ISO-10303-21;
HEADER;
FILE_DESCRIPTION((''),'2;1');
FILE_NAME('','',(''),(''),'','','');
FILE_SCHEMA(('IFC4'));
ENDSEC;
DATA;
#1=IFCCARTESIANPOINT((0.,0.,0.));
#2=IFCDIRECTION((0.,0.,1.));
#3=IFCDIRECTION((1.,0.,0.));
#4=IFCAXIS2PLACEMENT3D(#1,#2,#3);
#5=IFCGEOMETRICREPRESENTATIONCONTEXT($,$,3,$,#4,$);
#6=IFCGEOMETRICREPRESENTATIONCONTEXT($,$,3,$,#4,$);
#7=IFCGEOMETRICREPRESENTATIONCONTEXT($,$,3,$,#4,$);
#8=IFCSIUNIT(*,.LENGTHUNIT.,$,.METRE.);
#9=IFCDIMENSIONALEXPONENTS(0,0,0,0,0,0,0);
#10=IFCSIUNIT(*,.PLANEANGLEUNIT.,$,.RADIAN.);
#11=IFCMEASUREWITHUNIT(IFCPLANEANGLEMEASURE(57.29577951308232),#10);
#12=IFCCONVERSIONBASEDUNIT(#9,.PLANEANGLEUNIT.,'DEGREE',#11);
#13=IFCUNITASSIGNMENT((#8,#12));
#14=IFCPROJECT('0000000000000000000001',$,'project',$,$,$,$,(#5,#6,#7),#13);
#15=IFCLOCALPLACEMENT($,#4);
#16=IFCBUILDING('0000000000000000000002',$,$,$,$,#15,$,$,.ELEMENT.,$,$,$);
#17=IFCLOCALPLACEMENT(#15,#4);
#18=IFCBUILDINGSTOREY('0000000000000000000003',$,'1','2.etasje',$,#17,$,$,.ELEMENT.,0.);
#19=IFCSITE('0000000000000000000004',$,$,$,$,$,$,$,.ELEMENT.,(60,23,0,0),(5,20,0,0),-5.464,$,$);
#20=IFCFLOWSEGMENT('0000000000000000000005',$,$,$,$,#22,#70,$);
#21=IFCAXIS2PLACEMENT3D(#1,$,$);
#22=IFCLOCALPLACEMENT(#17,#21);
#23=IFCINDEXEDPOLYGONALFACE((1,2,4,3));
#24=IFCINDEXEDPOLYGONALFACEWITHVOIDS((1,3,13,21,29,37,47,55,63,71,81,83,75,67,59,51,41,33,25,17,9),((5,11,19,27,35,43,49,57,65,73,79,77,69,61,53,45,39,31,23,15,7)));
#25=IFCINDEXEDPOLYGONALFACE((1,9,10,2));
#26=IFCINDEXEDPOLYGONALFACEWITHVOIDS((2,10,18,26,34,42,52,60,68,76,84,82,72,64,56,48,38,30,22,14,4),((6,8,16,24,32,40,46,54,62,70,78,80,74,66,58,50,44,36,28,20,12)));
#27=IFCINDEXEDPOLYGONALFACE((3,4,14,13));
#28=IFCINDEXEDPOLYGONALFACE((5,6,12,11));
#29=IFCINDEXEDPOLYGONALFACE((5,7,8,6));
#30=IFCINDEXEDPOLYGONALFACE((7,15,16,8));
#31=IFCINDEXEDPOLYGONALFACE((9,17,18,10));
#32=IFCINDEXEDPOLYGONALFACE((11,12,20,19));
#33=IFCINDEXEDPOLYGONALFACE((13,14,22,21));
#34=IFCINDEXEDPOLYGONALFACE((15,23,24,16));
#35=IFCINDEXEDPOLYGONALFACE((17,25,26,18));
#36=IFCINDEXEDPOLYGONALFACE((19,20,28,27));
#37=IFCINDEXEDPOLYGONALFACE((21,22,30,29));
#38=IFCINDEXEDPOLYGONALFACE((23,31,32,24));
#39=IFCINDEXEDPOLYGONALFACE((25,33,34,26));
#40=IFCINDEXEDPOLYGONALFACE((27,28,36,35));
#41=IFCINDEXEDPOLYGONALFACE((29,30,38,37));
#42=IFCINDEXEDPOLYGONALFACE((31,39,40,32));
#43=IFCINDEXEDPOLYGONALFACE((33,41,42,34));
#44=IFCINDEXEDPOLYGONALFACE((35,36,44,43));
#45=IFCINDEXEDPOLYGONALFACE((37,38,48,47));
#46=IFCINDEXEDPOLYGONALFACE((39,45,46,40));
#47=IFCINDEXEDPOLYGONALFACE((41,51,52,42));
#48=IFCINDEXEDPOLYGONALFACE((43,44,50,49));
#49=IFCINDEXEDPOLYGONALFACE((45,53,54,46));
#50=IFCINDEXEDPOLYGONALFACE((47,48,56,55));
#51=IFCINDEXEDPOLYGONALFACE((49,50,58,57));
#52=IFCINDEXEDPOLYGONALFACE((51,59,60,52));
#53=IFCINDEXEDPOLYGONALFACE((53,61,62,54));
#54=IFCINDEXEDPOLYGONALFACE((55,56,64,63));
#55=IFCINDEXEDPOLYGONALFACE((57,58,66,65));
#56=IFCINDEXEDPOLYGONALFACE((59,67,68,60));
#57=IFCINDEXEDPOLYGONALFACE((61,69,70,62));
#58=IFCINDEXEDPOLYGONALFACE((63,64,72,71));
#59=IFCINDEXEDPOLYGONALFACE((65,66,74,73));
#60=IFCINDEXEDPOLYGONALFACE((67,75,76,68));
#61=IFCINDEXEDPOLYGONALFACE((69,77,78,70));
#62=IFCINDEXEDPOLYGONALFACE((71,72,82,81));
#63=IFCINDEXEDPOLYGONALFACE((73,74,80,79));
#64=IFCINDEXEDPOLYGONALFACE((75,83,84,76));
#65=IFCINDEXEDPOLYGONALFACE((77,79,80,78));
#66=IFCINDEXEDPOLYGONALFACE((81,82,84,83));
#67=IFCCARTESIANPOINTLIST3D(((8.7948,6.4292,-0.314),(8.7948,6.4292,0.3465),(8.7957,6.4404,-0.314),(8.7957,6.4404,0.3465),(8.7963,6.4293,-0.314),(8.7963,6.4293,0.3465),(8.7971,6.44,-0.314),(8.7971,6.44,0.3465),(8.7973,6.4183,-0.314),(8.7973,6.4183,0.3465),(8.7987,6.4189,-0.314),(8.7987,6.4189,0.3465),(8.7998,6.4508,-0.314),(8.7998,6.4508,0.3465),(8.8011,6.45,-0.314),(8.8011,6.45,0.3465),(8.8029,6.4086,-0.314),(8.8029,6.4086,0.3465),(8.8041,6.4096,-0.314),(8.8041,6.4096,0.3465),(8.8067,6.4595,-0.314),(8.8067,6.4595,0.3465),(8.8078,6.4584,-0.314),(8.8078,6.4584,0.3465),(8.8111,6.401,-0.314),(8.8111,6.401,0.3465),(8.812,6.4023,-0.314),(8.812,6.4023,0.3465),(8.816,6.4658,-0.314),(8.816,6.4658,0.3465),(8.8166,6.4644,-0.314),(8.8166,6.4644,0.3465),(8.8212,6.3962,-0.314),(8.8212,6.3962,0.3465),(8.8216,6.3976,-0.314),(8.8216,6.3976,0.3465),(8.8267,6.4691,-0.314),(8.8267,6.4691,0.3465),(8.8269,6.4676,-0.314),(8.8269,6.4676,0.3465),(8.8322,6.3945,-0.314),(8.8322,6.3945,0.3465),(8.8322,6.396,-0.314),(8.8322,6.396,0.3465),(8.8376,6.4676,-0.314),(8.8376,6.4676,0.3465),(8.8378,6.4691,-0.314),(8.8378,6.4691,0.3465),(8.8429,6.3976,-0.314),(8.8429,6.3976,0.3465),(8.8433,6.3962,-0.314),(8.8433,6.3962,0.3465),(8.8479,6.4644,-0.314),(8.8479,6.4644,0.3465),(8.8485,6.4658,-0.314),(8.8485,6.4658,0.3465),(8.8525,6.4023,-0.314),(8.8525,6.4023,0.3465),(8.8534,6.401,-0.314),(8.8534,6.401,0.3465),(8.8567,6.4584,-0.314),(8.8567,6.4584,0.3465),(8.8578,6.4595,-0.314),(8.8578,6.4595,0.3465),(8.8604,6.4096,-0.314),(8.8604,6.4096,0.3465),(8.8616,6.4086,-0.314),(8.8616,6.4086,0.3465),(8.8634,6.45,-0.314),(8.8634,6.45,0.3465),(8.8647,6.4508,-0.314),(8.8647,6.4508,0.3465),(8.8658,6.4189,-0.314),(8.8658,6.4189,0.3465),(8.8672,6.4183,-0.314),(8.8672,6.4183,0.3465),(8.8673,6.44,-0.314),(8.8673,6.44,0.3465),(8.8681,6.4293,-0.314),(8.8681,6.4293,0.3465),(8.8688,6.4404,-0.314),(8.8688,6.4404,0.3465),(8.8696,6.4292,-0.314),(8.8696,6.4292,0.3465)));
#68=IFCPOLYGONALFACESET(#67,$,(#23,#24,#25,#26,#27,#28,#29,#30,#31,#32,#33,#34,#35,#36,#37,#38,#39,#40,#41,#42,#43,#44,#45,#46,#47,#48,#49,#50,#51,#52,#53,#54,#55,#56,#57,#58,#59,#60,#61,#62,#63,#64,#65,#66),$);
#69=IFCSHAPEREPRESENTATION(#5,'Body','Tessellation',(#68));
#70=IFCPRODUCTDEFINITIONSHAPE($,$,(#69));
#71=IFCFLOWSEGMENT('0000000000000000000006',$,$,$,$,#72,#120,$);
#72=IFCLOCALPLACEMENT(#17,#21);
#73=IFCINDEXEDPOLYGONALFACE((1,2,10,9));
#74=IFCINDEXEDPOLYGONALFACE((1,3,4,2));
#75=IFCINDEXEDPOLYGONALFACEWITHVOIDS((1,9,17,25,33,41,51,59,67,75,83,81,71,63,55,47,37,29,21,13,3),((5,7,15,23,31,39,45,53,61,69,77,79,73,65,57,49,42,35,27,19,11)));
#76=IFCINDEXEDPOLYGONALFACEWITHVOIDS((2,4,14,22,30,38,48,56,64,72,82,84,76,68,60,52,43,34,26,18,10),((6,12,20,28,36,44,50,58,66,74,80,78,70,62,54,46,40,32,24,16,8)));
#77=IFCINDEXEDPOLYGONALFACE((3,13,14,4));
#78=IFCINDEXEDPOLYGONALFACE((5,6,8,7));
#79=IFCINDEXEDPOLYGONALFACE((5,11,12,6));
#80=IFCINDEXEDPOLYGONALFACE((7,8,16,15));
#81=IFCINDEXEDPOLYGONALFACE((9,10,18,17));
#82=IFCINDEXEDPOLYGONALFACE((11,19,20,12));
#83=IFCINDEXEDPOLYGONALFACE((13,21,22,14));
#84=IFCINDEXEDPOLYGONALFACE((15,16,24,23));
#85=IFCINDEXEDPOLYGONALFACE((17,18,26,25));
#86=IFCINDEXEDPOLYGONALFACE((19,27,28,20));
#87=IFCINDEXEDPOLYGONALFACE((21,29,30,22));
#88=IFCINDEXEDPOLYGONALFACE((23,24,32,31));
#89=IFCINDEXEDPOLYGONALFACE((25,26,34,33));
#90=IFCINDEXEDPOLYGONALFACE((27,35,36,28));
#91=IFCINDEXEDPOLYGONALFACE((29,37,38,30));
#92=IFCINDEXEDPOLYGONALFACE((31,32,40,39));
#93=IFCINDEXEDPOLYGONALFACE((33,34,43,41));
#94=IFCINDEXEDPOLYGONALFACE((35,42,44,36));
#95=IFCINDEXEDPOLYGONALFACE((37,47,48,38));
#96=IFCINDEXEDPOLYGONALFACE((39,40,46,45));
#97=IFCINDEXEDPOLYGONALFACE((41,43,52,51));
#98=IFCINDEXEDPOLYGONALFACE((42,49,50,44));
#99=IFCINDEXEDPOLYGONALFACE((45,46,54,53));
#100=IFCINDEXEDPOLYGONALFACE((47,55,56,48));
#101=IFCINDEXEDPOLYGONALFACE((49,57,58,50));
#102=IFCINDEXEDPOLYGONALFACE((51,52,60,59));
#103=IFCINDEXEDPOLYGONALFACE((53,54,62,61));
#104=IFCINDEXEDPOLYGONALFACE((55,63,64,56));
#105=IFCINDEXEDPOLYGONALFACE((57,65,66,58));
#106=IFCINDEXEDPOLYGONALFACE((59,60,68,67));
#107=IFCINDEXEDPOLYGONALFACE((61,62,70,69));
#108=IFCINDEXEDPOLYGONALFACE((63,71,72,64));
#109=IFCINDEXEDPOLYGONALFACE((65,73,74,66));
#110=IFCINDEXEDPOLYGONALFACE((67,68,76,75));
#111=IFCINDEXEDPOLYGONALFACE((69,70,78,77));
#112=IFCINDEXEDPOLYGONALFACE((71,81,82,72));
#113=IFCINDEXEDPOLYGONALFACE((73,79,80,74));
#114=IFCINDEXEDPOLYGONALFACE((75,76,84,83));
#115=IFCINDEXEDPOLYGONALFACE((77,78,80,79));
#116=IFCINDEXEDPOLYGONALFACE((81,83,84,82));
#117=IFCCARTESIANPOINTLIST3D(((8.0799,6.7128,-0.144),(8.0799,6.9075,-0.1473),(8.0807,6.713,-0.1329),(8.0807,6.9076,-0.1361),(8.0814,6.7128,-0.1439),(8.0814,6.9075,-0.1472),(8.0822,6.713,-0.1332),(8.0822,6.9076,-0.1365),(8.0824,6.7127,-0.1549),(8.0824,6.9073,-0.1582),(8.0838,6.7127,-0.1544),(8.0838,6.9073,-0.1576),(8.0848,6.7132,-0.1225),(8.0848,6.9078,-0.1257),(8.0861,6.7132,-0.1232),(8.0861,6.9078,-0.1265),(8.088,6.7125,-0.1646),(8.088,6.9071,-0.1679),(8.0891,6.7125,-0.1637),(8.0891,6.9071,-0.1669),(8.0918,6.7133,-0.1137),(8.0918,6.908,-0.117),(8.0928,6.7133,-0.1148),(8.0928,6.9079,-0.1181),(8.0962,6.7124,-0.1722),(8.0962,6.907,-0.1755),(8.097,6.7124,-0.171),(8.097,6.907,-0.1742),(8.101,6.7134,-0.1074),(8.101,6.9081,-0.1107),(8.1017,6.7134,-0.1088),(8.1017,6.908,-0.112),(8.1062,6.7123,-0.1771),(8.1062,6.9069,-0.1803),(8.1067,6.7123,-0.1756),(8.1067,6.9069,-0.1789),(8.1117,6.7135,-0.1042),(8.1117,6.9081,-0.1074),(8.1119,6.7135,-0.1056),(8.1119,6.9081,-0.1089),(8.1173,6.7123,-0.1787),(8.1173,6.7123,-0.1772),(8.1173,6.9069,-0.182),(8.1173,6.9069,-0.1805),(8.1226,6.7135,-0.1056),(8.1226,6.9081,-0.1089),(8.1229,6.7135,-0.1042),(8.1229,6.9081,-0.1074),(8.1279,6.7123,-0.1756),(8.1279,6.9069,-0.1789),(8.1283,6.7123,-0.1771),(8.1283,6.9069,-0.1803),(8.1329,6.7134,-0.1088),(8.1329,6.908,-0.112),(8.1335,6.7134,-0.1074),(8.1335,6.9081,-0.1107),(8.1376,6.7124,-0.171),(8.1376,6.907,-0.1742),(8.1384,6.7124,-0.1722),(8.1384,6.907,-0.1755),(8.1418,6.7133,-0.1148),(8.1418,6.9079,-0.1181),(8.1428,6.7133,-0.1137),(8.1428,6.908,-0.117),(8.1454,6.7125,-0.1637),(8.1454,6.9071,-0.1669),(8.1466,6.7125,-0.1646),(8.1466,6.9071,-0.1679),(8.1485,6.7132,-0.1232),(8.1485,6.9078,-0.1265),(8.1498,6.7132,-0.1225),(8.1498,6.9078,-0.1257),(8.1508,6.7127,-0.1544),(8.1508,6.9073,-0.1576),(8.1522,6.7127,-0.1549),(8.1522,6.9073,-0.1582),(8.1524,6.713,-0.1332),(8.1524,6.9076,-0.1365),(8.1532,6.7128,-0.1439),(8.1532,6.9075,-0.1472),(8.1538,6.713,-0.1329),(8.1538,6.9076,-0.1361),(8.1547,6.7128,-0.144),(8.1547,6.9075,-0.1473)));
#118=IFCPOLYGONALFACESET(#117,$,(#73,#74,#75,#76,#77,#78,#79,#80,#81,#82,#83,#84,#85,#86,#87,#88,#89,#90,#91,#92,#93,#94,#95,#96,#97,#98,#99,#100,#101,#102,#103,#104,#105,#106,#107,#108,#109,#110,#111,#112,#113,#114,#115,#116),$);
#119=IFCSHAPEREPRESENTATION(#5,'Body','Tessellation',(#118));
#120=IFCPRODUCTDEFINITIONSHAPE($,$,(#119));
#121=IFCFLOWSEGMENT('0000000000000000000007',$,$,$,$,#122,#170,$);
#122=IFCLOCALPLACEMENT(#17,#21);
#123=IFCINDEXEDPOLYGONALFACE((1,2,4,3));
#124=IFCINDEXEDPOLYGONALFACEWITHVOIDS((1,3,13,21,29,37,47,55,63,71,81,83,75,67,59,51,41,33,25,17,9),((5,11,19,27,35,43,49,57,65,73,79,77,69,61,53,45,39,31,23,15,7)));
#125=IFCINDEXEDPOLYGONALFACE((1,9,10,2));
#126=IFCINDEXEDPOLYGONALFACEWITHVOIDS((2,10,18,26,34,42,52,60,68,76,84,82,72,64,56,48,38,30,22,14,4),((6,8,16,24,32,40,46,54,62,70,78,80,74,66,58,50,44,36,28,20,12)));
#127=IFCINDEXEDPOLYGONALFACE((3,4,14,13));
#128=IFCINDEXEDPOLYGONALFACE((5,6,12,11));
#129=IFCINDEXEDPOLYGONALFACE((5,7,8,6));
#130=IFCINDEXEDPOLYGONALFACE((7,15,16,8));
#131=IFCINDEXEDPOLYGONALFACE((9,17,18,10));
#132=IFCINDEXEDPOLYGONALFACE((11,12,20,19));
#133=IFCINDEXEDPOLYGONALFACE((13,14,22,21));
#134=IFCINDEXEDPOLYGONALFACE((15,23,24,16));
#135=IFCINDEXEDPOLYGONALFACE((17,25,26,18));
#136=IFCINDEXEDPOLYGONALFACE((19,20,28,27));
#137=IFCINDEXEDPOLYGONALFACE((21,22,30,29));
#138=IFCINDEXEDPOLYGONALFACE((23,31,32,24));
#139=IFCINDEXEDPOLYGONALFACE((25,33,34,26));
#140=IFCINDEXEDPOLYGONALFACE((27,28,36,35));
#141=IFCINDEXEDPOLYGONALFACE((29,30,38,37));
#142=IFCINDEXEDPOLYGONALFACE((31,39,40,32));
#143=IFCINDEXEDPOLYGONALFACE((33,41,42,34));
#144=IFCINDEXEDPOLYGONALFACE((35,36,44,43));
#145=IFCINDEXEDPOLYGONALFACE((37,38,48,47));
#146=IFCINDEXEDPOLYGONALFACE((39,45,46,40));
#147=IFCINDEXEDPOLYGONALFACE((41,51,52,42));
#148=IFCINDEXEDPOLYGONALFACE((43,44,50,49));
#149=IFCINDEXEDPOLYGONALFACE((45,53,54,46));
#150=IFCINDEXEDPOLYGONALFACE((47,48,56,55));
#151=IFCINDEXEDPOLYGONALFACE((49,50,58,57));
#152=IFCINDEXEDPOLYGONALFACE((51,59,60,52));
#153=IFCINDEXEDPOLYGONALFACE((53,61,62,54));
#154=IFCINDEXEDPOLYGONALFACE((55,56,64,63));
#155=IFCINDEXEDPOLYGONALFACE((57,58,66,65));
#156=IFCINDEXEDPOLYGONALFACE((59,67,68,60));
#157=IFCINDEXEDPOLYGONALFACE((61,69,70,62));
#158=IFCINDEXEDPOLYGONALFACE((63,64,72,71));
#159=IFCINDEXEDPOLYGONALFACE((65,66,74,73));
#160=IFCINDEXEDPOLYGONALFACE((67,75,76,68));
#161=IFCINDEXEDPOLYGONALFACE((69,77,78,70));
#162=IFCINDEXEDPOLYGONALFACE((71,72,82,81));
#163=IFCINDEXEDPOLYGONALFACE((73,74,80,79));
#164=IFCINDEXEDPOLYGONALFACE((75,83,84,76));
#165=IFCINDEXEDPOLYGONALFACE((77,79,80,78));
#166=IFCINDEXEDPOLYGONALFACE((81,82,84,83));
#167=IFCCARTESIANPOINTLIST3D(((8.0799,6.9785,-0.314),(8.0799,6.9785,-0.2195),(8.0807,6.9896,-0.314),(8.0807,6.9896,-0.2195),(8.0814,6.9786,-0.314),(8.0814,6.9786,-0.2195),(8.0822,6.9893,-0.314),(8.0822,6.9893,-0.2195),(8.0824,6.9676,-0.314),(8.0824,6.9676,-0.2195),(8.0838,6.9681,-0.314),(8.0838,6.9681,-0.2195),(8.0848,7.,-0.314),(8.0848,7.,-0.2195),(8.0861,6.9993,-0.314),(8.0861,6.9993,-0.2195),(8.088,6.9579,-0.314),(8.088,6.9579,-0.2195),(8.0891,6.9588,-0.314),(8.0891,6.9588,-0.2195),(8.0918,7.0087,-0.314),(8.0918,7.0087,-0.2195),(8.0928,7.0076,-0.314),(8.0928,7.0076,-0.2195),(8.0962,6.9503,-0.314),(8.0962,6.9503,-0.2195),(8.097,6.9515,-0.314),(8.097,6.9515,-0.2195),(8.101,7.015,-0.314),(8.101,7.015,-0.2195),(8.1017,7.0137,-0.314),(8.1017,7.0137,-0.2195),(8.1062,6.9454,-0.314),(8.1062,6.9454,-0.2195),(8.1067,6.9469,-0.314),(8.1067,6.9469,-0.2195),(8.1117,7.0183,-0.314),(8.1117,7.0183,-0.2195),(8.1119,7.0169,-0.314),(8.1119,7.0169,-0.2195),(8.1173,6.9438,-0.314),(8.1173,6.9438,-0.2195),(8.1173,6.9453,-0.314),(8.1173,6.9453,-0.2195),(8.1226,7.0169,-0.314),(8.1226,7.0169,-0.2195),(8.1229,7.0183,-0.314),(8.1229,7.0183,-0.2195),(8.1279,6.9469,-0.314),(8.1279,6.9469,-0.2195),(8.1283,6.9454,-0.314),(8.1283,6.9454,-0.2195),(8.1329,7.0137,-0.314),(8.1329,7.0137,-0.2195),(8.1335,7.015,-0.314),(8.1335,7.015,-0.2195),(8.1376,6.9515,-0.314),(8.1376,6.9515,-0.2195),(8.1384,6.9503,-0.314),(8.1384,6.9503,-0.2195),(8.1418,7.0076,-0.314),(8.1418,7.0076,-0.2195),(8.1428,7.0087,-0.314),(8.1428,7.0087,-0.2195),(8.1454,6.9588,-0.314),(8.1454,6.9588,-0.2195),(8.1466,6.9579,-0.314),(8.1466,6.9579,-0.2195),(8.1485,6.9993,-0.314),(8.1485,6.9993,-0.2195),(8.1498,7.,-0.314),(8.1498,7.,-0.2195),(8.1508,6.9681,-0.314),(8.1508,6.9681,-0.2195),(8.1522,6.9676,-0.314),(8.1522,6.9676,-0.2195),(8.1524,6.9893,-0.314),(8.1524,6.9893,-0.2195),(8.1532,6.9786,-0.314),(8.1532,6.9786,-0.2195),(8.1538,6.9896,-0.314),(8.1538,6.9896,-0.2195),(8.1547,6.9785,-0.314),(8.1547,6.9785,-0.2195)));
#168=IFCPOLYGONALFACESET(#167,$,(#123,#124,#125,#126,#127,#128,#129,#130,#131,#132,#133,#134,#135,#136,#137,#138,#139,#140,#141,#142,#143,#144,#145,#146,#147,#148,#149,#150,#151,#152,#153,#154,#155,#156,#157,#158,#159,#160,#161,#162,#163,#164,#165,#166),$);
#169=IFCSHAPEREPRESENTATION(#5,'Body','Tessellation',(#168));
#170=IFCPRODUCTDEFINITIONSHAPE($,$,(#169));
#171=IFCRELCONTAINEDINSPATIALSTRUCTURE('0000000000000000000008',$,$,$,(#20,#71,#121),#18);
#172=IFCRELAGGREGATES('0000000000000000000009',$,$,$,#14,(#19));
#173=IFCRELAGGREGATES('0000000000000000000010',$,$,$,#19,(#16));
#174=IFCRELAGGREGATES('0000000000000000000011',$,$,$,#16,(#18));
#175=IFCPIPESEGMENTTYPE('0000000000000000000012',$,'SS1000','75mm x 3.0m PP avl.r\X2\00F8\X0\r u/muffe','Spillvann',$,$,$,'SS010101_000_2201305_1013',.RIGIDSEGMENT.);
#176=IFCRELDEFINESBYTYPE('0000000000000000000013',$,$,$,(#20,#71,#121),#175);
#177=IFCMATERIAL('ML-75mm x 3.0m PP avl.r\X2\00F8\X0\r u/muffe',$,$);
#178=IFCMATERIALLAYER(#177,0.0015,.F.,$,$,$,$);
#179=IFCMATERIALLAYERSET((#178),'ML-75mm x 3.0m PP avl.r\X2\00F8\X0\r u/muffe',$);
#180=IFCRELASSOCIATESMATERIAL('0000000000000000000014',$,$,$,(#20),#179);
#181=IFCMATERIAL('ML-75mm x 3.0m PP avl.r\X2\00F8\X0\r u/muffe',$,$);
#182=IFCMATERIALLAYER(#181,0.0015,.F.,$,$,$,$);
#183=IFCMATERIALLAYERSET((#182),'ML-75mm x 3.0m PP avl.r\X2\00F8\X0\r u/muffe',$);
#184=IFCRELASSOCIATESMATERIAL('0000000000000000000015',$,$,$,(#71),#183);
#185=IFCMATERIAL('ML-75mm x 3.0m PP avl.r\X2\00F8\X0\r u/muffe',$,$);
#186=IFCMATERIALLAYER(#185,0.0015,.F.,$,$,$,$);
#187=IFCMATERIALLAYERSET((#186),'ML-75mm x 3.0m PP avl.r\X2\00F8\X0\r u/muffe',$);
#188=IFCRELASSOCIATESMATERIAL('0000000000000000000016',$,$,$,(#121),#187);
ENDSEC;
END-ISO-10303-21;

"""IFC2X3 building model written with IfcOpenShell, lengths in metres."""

from ifc_helpers import new_model, entity, si_unit, converted_unit, frame, origin_with_axes, origin_2d_with_axis, place, context, project, spatial, hollow_circle, extrude, material, layer, layer_set, layer_usage, type_object, element, save


model = new_model("IFC2X3")

# Units and contexts
context_of_model_1 = context(None, 3, world=origin_with_axes())
context_of_model_2 = context(None, 3, world=origin_with_axes())
context_of_model_3 = context(None, 3, world=origin_with_axes())
ifc_project = project(units=[si_unit("LENGTHUNIT", "METRE"), converted_unit("PLANEANGLEUNIT", "DEGREE", entity("IfcPlaneAngleMeasure", 57.29577951308232), si_unit("PLANEANGLEUNIT", "RADIAN"), dimensions=[0, 0, 0, 0, 0, 0, 0])], contexts=[context_of_model_1, context_of_model_2, context_of_model_3])

# Site, building, storey
site = spatial("IfcSite", under=ifc_project, CompositionType="ELEMENT", RefLatitude=(60, 23, 0, 0), RefLongitude=(5, 20, 0, 0), RefElevation=-5.464)
building_placement = place(None, origin_with_axes())
building = spatial("IfcBuilding", under=site, at=building_placement, CompositionType="ELEMENT")
storey_placement = place(building_placement, origin_with_axes())
storey = spatial("IfcBuildingStorey", under=building, at=storey_placement, Name="1", Description="2.etasje", CompositionType="ELEMENT", Elevation=0.0)

# Flow segments
pipe_segment_type_1 = type_object("IfcPipeSegmentType", Name="SS1000", Description="75mm x 3.0m PP avl.rør u/muffe", ApplicableOccurrence="Spillvann", ElementType="SS010101_000_2201305_1013", PredefinedType="RIGIDSEGMENT")
ifc_material_1 = material(Name="ML-75mm x 3.0m PP avl.rør u/muffe")
ifc_layer_1 = layer(ifc_material_1, 0.0015, ventilated=False)
ifc_layer_set_1 = layer_set([ifc_layer_1], Name="ML-75mm x 3.0m PP avl.rør u/muffe")
ifc_layer_usage_1 = layer_usage(ifc_layer_set_1, "AXIS2", "POSITIVE", 0.0)
flow_segment_1_placement = place(storey_placement, frame((8.8322, 6.432, 0.3465), z_axis=(0.0, 0.0, -1.0), x_axis=(0.0, -1.0, 0.0)))
element("IfcFlowSegment", 1, at=flow_segment_1_placement, inside=storey, type_object=pipe_segment_type_1, material=ifc_layer_usage_1, context=context_of_model_1, shape_type="SweptSolid", body=[
    extrude(hollow_circle(Radius=0.0375, WallThickness=0.0015, at=origin_2d_with_axis()), origin_with_axes(), (0.0, 0.0, 1.0), 0.6605),
])
ifc_material_2 = material(Name="ML-75mm x 3.0m PP avl.rør u/muffe")
ifc_layer_2 = layer(ifc_material_2, 0.0015, ventilated=False)
ifc_layer_set_2 = layer_set([ifc_layer_2], Name="ML-75mm x 3.0m PP avl.rør u/muffe")
ifc_layer_usage_2 = layer_usage(ifc_layer_set_2, "AXIS2", "POSITIVE", 0.0)
flow_segment_2_placement = place(storey_placement, frame((8.1173, 6.7129, -0.1412), z_axis=(0.0, 0.999861, -0.016665), x_axis=(0.0, -0.016665, -0.999861)))
element("IfcFlowSegment", 2, at=flow_segment_2_placement, inside=storey, type_object=pipe_segment_type_1, material=ifc_layer_usage_2, context=context_of_model_1, shape_type="SweptSolid", body=[
    extrude(hollow_circle(Radius=0.0375, WallThickness=0.0015, at=origin_2d_with_axis()), origin_with_axes(), (0.0, 0.0, 1.0), 0.1947),
])
ifc_material_3 = material(Name="ML-75mm x 3.0m PP avl.rør u/muffe")
ifc_layer_3 = layer(ifc_material_3, 0.0015, ventilated=False)
ifc_layer_set_3 = layer_set([ifc_layer_3], Name="ML-75mm x 3.0m PP avl.rør u/muffe")
ifc_layer_usage_3 = layer_usage(ifc_layer_set_3, "AXIS2", "POSITIVE", 0.0)
flow_segment_3_placement = place(storey_placement, frame((8.1173, 6.9813, -0.2195), z_axis=(0.0, 0.0, -1.0), x_axis=(0.0, -1.0, 0.0)))
element("IfcFlowSegment", 3, at=flow_segment_3_placement, inside=storey, type_object=pipe_segment_type_1, material=ifc_layer_usage_3, context=context_of_model_1, shape_type="SweptSolid", body=[
    extrude(hollow_circle(Radius=0.0375, WallThickness=0.0015, at=origin_2d_with_axis()), origin_with_axes(), (0.0, 0.0, 1.0), 0.0945),
])

save(model, "model.ifc")
